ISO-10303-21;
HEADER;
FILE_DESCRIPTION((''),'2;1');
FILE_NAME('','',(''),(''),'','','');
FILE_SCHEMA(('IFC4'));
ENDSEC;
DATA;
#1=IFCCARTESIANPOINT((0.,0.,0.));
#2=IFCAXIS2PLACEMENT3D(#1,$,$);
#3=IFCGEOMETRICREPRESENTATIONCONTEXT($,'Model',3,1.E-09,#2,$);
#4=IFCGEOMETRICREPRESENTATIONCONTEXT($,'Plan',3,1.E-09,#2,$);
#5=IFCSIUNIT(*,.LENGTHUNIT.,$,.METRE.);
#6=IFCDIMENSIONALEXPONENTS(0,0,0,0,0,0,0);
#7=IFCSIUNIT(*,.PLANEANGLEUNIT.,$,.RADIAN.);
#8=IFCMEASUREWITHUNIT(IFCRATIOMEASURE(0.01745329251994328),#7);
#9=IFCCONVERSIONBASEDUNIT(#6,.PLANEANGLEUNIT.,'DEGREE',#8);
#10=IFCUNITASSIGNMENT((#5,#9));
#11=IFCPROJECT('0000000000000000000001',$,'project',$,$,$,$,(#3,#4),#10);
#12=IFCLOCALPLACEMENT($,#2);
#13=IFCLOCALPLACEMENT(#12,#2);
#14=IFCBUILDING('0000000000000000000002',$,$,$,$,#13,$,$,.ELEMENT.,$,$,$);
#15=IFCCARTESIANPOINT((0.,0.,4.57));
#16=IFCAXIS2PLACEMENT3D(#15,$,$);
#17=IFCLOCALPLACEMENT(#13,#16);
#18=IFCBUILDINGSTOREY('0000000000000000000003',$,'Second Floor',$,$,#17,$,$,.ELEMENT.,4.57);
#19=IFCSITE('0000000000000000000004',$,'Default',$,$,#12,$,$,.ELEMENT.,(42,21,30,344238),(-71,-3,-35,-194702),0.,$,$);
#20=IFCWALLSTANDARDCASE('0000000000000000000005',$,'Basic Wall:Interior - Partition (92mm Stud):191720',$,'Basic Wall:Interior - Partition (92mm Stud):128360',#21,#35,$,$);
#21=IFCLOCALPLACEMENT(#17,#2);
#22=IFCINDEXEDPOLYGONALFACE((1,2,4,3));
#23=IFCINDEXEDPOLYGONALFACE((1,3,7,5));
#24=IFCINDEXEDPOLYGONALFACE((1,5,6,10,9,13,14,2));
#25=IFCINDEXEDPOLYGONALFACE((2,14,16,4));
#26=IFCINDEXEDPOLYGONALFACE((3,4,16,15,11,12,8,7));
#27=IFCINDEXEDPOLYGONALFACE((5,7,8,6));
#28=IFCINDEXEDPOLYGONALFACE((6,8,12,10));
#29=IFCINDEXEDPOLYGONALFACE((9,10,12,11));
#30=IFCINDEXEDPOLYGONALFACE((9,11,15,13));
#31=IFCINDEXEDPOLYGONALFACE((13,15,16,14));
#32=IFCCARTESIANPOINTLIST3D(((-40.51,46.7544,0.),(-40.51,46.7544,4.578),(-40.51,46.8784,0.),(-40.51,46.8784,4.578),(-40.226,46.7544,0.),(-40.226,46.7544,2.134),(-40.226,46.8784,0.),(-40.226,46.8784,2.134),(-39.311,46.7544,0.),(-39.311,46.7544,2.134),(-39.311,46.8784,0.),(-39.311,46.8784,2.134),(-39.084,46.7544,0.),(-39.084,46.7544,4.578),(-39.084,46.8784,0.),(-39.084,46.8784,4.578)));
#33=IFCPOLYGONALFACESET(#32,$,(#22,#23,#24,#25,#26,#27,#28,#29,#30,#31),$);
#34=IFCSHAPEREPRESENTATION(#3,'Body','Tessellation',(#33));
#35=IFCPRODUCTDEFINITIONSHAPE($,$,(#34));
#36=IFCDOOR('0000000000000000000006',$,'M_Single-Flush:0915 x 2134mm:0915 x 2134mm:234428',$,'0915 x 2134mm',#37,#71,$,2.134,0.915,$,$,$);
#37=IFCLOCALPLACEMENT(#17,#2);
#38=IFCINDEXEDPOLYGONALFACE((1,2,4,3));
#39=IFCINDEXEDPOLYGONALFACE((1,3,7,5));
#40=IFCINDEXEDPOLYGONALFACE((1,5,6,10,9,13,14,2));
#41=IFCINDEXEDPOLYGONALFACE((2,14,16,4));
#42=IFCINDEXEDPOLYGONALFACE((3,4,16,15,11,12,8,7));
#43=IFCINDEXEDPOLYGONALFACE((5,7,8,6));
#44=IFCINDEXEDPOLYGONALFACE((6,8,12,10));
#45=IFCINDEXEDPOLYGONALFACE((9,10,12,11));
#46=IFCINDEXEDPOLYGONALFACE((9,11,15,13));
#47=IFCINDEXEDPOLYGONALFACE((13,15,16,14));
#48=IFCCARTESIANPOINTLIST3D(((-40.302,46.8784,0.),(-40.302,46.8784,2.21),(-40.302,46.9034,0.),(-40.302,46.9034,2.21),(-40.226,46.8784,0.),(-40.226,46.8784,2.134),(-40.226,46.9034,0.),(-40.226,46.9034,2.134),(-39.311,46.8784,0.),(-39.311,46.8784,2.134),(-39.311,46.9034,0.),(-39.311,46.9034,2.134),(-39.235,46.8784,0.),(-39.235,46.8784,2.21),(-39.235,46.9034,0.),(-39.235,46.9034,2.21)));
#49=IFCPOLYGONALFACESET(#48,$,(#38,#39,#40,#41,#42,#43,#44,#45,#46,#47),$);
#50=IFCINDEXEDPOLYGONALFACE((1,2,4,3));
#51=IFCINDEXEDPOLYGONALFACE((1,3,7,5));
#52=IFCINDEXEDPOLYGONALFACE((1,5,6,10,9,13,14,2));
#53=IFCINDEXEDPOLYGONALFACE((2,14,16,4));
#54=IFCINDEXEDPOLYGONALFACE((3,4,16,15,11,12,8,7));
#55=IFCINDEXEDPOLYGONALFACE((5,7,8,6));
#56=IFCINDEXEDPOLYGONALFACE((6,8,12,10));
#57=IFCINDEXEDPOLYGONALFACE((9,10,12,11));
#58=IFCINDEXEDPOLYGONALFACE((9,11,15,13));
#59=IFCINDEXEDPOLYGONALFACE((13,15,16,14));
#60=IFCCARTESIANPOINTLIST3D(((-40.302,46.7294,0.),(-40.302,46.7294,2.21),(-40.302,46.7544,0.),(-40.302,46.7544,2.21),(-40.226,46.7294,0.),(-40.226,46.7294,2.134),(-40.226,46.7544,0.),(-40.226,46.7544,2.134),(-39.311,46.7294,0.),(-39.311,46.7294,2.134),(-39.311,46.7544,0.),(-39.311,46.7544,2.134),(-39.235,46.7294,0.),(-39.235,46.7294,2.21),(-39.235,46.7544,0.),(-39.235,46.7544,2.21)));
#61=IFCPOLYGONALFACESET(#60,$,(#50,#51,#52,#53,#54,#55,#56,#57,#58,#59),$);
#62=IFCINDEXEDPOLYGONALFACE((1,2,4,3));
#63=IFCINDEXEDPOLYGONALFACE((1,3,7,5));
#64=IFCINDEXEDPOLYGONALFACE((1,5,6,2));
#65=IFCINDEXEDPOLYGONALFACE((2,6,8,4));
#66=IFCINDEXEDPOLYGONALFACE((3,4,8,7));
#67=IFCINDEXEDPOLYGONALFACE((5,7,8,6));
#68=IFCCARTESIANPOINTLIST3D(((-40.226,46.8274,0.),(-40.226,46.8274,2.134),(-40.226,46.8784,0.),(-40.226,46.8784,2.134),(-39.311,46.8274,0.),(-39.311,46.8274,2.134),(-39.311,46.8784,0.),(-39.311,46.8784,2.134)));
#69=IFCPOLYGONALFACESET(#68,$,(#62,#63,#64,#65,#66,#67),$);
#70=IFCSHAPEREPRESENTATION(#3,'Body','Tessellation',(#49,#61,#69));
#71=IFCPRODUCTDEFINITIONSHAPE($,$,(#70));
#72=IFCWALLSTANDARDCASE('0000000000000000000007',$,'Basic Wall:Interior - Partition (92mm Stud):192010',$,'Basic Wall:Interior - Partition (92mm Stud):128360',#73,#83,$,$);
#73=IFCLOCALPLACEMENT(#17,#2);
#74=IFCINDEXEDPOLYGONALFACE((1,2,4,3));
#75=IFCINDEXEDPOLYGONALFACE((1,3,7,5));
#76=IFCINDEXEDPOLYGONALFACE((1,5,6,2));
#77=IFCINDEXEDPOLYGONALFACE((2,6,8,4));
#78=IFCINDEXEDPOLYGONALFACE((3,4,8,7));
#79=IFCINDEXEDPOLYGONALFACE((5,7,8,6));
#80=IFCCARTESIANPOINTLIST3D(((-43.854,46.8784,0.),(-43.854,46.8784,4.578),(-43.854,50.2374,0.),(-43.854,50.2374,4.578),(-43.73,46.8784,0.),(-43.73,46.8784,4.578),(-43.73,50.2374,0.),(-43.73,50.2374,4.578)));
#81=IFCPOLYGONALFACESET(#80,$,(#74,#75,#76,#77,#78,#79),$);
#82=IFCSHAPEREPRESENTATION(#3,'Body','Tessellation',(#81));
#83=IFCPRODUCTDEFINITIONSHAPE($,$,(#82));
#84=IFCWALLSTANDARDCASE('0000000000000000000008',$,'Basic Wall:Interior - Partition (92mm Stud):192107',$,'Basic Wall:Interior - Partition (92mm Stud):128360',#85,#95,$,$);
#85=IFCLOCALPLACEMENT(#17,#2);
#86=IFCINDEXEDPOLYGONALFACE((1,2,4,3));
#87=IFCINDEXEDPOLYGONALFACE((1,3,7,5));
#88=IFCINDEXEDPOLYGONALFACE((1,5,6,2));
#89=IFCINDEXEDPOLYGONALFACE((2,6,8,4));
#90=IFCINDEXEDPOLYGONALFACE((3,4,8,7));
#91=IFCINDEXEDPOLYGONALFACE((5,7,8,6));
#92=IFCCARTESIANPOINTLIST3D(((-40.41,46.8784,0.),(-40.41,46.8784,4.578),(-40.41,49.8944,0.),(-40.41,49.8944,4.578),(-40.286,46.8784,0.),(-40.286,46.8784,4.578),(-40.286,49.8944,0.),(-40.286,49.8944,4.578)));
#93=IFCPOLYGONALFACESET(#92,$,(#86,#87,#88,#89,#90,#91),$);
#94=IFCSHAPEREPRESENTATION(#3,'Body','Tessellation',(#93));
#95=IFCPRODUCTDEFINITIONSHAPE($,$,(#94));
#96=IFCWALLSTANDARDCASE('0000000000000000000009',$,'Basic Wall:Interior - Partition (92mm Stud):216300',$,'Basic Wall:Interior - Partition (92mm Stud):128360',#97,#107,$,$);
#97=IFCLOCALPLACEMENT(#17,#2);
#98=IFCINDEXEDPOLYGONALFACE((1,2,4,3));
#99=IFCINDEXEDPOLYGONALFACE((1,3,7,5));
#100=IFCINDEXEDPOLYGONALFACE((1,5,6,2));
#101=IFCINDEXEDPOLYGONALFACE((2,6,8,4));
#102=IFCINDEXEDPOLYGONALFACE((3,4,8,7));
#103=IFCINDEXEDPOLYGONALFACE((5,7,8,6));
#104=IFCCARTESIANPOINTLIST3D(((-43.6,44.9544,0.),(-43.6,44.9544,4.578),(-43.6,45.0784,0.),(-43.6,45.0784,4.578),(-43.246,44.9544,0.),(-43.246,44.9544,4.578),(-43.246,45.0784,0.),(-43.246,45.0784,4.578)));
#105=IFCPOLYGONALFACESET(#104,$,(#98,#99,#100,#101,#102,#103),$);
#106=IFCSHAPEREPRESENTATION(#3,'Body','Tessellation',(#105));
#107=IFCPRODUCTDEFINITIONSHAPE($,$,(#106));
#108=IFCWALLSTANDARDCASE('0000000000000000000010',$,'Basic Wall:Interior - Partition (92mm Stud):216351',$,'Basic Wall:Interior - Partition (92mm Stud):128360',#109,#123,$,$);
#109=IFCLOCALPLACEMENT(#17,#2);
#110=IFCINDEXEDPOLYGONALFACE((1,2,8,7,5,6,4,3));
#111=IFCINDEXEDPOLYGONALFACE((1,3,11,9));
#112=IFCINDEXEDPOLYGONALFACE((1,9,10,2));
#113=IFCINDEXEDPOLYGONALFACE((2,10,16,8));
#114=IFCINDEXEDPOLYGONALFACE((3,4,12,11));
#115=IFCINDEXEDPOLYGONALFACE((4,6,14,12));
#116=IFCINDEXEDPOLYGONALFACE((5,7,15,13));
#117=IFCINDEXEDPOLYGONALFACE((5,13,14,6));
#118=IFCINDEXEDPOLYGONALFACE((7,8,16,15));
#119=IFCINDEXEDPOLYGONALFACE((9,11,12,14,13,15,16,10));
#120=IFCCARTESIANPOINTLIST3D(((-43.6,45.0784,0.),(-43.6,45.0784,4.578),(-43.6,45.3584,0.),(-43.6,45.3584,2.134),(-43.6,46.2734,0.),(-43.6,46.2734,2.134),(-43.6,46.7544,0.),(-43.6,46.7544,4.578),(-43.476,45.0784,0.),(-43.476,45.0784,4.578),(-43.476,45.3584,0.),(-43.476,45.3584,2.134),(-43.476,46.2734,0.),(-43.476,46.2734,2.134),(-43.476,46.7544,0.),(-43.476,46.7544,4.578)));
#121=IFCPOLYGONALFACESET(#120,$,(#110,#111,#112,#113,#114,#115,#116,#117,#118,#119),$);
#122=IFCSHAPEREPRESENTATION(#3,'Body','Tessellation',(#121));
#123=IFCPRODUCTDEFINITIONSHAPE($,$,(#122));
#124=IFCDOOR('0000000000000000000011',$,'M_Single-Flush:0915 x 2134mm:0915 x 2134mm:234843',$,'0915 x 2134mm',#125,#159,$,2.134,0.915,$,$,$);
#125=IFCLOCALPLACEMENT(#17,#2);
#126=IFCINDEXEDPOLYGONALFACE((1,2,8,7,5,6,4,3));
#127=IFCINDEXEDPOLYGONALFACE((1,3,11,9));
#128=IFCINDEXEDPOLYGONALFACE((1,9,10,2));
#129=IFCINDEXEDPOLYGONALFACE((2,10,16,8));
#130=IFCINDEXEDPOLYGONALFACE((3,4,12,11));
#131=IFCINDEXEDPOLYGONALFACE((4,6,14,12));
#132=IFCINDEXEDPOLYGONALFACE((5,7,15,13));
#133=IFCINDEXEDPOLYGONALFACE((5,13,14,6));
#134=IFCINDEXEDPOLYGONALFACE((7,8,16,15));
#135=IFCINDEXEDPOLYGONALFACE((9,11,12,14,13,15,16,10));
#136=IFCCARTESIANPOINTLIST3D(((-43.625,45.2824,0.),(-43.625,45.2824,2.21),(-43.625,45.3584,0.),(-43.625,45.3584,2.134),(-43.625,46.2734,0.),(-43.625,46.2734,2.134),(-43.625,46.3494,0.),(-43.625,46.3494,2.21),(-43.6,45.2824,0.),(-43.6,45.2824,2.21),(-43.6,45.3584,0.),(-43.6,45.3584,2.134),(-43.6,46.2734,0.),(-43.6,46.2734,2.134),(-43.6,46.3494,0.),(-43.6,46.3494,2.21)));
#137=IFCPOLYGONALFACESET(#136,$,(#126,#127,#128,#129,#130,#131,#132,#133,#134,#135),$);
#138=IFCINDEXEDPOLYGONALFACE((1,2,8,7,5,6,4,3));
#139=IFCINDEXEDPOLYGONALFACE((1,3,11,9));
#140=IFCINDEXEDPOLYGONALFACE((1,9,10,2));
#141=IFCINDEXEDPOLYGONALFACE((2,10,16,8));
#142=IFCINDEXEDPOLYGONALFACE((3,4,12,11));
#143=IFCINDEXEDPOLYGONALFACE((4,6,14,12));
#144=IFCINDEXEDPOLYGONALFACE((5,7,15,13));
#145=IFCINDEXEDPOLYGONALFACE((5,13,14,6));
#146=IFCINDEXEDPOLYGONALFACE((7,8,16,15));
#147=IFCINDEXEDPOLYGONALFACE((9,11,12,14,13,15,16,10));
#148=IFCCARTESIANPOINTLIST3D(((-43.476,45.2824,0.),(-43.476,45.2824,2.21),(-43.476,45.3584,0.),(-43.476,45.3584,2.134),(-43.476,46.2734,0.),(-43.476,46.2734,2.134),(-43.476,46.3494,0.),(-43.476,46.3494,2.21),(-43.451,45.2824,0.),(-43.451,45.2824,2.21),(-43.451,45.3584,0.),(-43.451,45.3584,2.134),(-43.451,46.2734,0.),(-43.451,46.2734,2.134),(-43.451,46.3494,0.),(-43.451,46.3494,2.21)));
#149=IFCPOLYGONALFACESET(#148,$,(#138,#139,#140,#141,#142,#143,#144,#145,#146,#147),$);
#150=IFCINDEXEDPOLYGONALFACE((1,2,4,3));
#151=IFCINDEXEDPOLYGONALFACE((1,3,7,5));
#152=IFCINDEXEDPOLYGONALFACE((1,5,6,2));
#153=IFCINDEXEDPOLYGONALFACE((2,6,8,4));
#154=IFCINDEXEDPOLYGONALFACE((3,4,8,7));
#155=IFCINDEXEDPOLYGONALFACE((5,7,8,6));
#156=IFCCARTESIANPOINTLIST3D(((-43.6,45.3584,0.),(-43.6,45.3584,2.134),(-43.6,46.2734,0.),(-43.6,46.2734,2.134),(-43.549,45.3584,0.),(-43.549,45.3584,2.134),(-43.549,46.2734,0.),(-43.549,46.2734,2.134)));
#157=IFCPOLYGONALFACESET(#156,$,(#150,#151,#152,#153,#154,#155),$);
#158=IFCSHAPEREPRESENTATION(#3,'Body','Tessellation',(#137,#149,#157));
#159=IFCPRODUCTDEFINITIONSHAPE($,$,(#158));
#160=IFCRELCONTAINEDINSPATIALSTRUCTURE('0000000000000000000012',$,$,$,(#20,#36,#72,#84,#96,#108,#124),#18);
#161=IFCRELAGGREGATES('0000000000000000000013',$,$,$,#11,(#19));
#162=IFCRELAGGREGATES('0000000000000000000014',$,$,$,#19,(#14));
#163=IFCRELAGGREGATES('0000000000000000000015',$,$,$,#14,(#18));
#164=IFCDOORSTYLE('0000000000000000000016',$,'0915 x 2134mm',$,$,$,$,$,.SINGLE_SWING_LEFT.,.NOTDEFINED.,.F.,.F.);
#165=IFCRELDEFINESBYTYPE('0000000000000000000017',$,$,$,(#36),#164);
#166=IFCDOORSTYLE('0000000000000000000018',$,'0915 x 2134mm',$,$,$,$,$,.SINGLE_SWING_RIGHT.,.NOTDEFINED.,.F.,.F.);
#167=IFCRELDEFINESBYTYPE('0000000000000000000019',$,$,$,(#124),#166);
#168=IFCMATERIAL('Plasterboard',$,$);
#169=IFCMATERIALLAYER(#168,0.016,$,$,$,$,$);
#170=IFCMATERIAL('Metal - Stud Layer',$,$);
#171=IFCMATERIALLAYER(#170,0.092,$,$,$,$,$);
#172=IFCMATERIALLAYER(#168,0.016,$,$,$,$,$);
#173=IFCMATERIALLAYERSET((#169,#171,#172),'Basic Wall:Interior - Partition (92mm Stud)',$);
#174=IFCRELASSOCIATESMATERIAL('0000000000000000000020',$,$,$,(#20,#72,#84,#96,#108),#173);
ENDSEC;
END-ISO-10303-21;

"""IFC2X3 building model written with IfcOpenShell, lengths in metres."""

from ifc_helpers import new_model, entity, si_unit, converted_unit, frame, frame_2d, origin, origin_2d_with_axis, place, context, project, spatial, polyline, rectangle, outline, extrude, source, transform, mapped, material, layer, layer_set, layer_usage, type_object, type_shapes, element, fill, save


model = new_model("IFC2X3")

# Units and contexts
model_context = context("Model", 3, precision=1e-09, world=origin())
plan_context = context("Plan", 3, precision=1e-09, world=origin())
ifc_project = project(units=[si_unit("LENGTHUNIT", "METRE"), converted_unit("PLANEANGLEUNIT", "DEGREE", entity("IfcRatioMeasure", 0.01745329251994328), si_unit("PLANEANGLEUNIT", "RADIAN"), dimensions=[0, 0, 0, 0, 0, 0, 0])], contexts=[model_context, plan_context])

# Site, building, storey
site_placement = place(None, origin())
site = spatial("IfcSite", under=ifc_project, at=site_placement, Name="Default", CompositionType="ELEMENT", RefLatitude=(42, 21, 30, 344238), RefLongitude=(-71, -3, -35, -194702), RefElevation=0.0)
building_placement = place(site_placement, origin())
building = spatial("IfcBuilding", under=site, at=building_placement, CompositionType="ELEMENT")
storey_placement = place(building_placement, frame((0.0, 0.0, 4.57)))
storey = spatial("IfcBuildingStorey", under=building, at=storey_placement, Name="Second Floor", CompositionType="ELEMENT", Elevation=4.57)

# Shared definitions
ifc_material_1 = material(Name="Metal - Stud Layer")
ifc_material_2 = material(Name="Plasterboard")

# Wall, opening, door
ifc_layer_1 = layer(ifc_material_2, 0.016)
ifc_layer_2 = layer(ifc_material_1, 0.092)
ifc_layer_3 = layer(ifc_material_2, 0.016)
ifc_layer_set_1 = layer_set([ifc_layer_1, ifc_layer_2, ifc_layer_3], Name="Basic Wall:Interior - Partition (92mm Stud)")
ifc_layer_usage_1 = layer_usage(ifc_layer_set_1, "AXIS2", "NEGATIVE", 0.062)
wall_1_placement = place(storey_placement, frame((-39.084, 46.8164, 0.0), z_axis=(0.0, 0.0, 1.0), x_axis=(-1.0, 0.0, 0.0)))
wall_1 = element("IfcWallStandardCase", 1, at=wall_1_placement, inside=storey, material=ifc_layer_usage_1, Name="Basic Wall:Interior - Partition (92mm Stud):191720", ObjectType="Basic Wall:Interior - Partition (92mm Stud):128360", context=model_context, shape_type="SweptSolid", body=[
    extrude(rectangle(XDim=1.426, YDim=0.124, at=frame_2d((0.713, 0.0), x_axis=(-1.0, 0.0))), origin(), (0.0, 0.0, 1.0), 4.578),
])
opening_1_placement = place(wall_1_placement, frame((1.142, 0.062, 0.0)))
opening_1 = element("IfcOpeningElement", 2, at=opening_1_placement, cuts=wall_1, ObjectType="Opening", context=model_context, shape_type="SweptSolid", body=[
    extrude(rectangle(XDim=0.915, YDim=2.134, at=frame_2d((1.067, 0.4575), x_axis=(0.0, -1.0))), frame((0.0, 0.0, 0.0), z_axis=(0.0, -1.0, 0.0), x_axis=(0.0, 0.0, 1.0)), (0.0, 0.0, 1.0), 0.124),
])
door_style_1 = type_object("IfcDoorStyle", Name="0915 x 2134mm", ConstructionType="NOTDEFINED", OperationType="SINGLE_SWING_LEFT", ParameterTakesPrecedence=False, Sizeable=False)
shared_shape_1 = source(origin(), model_context, "Body", "SweptSolid", [
    extrude(outline(polyline([(-0.5335, -1.124), (0.5335, -1.124), (0.5335, 1.086), (0.4575, 1.086), (0.4575, -1.048), (-0.4575, -1.048), (-0.4575, 1.086), (-0.5335, 1.086), (-0.5335, -1.124)])), frame((0.4575, 0.149, 1.086), z_axis=(0.0, -1.0, 0.0), x_axis=(-1.0, 0.0, 0.0)), (0.0, 0.0, 1.0), 0.025),
    extrude(outline(polyline([(-1.124, -0.5335), (1.086, -0.5335), (1.086, -0.4575), (-1.048, -0.4575), (-1.048, 0.4575), (1.086, 0.4575), (1.086, 0.5335), (-1.124, 0.5335), (-1.124, -0.5335)])), frame((0.4575, 0.0, 1.086), z_axis=(0.0, -1.0, 0.0), x_axis=(0.0, 0.0, -1.0)), (0.0, 0.0, 1.0), 0.025),
    extrude(rectangle(XDim=0.915, YDim=0.051, at=origin_2d_with_axis()), frame((0.4575, 0.0985, 0.0)), (0.0, 0.0, 1.0), 2.134),
])
type_shapes(door_style_1, [shared_shape_1])
door_1_placement = place(opening_1_placement, frame((0.0, 0.0, 0.0), z_axis=(0.0, 0.0, 1.0), x_axis=(-1.0, 0.0, 0.0)))
door_1 = element("IfcDoor", 3, at=door_1_placement, inside=storey, type_object=door_style_1, Name="M_Single-Flush:0915 x 2134mm:0915 x 2134mm:234428", ObjectType="0915 x 2134mm", OverallHeight=2.134, OverallWidth=0.915, context=model_context, shape_type="MappedRepresentation", body=[
    mapped(shared_shape_1, transform((0.0, 0.0, 0.0), scale=1.0)),
])
fill(opening_1, door_1)

# Walls
ifc_layer_usage_2 = layer_usage(ifc_layer_set_1, "AXIS2", "NEGATIVE", 0.062)
wall_2_placement = place(storey_placement, frame((-43.792, 50.2374, 0.0), z_axis=(0.0, 0.0, 1.0), x_axis=(0.0, -1.0, 0.0)))
element("IfcWallStandardCase", 4, at=wall_2_placement, inside=storey, material=ifc_layer_usage_2, Name="Basic Wall:Interior - Partition (92mm Stud):192010", ObjectType="Basic Wall:Interior - Partition (92mm Stud):128360", context=model_context, shape_type="SweptSolid", body=[
    extrude(rectangle(XDim=3.359, YDim=0.124, at=frame_2d((1.6795, 0.0), x_axis=(-1.0, 0.0))), origin(), (0.0, 0.0, 1.0), 4.578),
])
ifc_layer_usage_3 = layer_usage(ifc_layer_set_1, "AXIS2", "NEGATIVE", 0.062)
wall_3_placement = place(storey_placement, frame((-40.348, 46.8784, 0.0), z_axis=(0.0, 0.0, 1.0), x_axis=(0.0, 1.0, 0.0)))
element("IfcWallStandardCase", 5, at=wall_3_placement, inside=storey, material=ifc_layer_usage_3, Name="Basic Wall:Interior - Partition (92mm Stud):192107", ObjectType="Basic Wall:Interior - Partition (92mm Stud):128360", context=model_context, shape_type="SweptSolid", body=[
    extrude(rectangle(XDim=3.016, YDim=0.124, at=frame_2d((1.508, 0.0), x_axis=(-1.0, 0.0))), origin(), (0.0, 0.0, 1.0), 4.578),
])
ifc_layer_usage_4 = layer_usage(ifc_layer_set_1, "AXIS2", "NEGATIVE", 0.062)
wall_4_placement = place(storey_placement, frame((-43.246, 45.0164, 0.0), z_axis=(0.0, 0.0, 1.0), x_axis=(-1.0, 0.0, 0.0)))
element("IfcWallStandardCase", 6, at=wall_4_placement, inside=storey, material=ifc_layer_usage_4, Name="Basic Wall:Interior - Partition (92mm Stud):216300", ObjectType="Basic Wall:Interior - Partition (92mm Stud):128360", context=model_context, shape_type="SweptSolid", body=[
    extrude(rectangle(XDim=0.354, YDim=0.124, at=frame_2d((0.177, 0.0), x_axis=(-1.0, 0.0))), origin(), (0.0, 0.0, 1.0), 4.578),
])

# Wall, opening, door
ifc_layer_usage_5 = layer_usage(ifc_layer_set_1, "AXIS2", "NEGATIVE", 0.062)
wall_5_placement = place(storey_placement, frame((-43.538, 45.0784, 0.0), z_axis=(0.0, 0.0, 1.0), x_axis=(0.0, 1.0, 0.0)))
wall_5 = element("IfcWallStandardCase", 7, at=wall_5_placement, inside=storey, material=ifc_layer_usage_5, Name="Basic Wall:Interior - Partition (92mm Stud):216351", ObjectType="Basic Wall:Interior - Partition (92mm Stud):128360", context=model_context, shape_type="SweptSolid", body=[
    extrude(rectangle(XDim=1.676, YDim=0.124, at=frame_2d((0.838, 0.0), x_axis=(-1.0, 0.0))), origin(), (0.0, 0.0, 1.0), 4.578),
])
opening_2_placement = place(wall_5_placement, frame((0.28, -0.062, 0.0)))
opening_2 = element("IfcOpeningElement", 8, at=opening_2_placement, cuts=wall_5, ObjectType="Opening", context=model_context, shape_type="SweptSolid", body=[
    extrude(rectangle(XDim=0.915, YDim=2.134, at=frame_2d((1.067, 0.4575), x_axis=(0.0, 1.0))), frame((0.0, 0.0, 0.0), z_axis=(0.0, 1.0, 0.0), x_axis=(0.0, 0.0, 1.0)), (0.0, 0.0, 1.0), 0.124),
])
door_style_2 = type_object("IfcDoorStyle", Name="0915 x 2134mm", ConstructionType="NOTDEFINED", OperationType="SINGLE_SWING_RIGHT", ParameterTakesPrecedence=False, Sizeable=False)
shared_shape_2 = source(origin(), model_context, "Body", "SweptSolid", [
    extrude(outline(polyline([(-0.5335, -1.124), (0.5335, -1.124), (0.5335, 1.086), (0.4575, 1.086), (0.4575, -1.048), (-0.4575, -1.048), (-0.4575, 1.086), (-0.5335, 1.086), (-0.5335, -1.124)])), frame((0.4575, 0.124, 1.086), z_axis=(0.0, 1.0, 0.0), x_axis=(1.0, 0.0, 0.0)), (0.0, 0.0, 1.0), 0.025),
    extrude(outline(polyline([(-1.124, -0.5335), (1.086, -0.5335), (1.086, -0.4575), (-1.048, -0.4575), (-1.048, 0.4575), (1.086, 0.4575), (1.086, 0.5335), (-1.124, 0.5335), (-1.124, -0.5335)])), frame((0.4575, -0.025, 1.086), z_axis=(0.0, 1.0, 0.0), x_axis=(0.0, 0.0, -1.0)), (0.0, 0.0, 1.0), 0.025),
    extrude(rectangle(XDim=0.051, YDim=0.915, at=origin_2d_with_axis()), frame((0.4575, 0.0985, 0.0), z_axis=(0.0, 0.0, 1.0), x_axis=(0.0, 1.0, 0.0)), (0.0, 0.0, 1.0), 2.134),
])
type_shapes(door_style_2, [shared_shape_2])
door_2_placement = place(opening_2_placement, origin())
door_2 = element("IfcDoor", 9, at=door_2_placement, inside=storey, type_object=door_style_2, Name="M_Single-Flush:0915 x 2134mm:0915 x 2134mm:234843", ObjectType="0915 x 2134mm", OverallHeight=2.134, OverallWidth=0.915, context=model_context, shape_type="MappedRepresentation", body=[
    mapped(shared_shape_2, transform((0.0, 0.0, 0.0), scale=1.0)),
])
fill(opening_2, door_2)

save(model, "model.ifc")
